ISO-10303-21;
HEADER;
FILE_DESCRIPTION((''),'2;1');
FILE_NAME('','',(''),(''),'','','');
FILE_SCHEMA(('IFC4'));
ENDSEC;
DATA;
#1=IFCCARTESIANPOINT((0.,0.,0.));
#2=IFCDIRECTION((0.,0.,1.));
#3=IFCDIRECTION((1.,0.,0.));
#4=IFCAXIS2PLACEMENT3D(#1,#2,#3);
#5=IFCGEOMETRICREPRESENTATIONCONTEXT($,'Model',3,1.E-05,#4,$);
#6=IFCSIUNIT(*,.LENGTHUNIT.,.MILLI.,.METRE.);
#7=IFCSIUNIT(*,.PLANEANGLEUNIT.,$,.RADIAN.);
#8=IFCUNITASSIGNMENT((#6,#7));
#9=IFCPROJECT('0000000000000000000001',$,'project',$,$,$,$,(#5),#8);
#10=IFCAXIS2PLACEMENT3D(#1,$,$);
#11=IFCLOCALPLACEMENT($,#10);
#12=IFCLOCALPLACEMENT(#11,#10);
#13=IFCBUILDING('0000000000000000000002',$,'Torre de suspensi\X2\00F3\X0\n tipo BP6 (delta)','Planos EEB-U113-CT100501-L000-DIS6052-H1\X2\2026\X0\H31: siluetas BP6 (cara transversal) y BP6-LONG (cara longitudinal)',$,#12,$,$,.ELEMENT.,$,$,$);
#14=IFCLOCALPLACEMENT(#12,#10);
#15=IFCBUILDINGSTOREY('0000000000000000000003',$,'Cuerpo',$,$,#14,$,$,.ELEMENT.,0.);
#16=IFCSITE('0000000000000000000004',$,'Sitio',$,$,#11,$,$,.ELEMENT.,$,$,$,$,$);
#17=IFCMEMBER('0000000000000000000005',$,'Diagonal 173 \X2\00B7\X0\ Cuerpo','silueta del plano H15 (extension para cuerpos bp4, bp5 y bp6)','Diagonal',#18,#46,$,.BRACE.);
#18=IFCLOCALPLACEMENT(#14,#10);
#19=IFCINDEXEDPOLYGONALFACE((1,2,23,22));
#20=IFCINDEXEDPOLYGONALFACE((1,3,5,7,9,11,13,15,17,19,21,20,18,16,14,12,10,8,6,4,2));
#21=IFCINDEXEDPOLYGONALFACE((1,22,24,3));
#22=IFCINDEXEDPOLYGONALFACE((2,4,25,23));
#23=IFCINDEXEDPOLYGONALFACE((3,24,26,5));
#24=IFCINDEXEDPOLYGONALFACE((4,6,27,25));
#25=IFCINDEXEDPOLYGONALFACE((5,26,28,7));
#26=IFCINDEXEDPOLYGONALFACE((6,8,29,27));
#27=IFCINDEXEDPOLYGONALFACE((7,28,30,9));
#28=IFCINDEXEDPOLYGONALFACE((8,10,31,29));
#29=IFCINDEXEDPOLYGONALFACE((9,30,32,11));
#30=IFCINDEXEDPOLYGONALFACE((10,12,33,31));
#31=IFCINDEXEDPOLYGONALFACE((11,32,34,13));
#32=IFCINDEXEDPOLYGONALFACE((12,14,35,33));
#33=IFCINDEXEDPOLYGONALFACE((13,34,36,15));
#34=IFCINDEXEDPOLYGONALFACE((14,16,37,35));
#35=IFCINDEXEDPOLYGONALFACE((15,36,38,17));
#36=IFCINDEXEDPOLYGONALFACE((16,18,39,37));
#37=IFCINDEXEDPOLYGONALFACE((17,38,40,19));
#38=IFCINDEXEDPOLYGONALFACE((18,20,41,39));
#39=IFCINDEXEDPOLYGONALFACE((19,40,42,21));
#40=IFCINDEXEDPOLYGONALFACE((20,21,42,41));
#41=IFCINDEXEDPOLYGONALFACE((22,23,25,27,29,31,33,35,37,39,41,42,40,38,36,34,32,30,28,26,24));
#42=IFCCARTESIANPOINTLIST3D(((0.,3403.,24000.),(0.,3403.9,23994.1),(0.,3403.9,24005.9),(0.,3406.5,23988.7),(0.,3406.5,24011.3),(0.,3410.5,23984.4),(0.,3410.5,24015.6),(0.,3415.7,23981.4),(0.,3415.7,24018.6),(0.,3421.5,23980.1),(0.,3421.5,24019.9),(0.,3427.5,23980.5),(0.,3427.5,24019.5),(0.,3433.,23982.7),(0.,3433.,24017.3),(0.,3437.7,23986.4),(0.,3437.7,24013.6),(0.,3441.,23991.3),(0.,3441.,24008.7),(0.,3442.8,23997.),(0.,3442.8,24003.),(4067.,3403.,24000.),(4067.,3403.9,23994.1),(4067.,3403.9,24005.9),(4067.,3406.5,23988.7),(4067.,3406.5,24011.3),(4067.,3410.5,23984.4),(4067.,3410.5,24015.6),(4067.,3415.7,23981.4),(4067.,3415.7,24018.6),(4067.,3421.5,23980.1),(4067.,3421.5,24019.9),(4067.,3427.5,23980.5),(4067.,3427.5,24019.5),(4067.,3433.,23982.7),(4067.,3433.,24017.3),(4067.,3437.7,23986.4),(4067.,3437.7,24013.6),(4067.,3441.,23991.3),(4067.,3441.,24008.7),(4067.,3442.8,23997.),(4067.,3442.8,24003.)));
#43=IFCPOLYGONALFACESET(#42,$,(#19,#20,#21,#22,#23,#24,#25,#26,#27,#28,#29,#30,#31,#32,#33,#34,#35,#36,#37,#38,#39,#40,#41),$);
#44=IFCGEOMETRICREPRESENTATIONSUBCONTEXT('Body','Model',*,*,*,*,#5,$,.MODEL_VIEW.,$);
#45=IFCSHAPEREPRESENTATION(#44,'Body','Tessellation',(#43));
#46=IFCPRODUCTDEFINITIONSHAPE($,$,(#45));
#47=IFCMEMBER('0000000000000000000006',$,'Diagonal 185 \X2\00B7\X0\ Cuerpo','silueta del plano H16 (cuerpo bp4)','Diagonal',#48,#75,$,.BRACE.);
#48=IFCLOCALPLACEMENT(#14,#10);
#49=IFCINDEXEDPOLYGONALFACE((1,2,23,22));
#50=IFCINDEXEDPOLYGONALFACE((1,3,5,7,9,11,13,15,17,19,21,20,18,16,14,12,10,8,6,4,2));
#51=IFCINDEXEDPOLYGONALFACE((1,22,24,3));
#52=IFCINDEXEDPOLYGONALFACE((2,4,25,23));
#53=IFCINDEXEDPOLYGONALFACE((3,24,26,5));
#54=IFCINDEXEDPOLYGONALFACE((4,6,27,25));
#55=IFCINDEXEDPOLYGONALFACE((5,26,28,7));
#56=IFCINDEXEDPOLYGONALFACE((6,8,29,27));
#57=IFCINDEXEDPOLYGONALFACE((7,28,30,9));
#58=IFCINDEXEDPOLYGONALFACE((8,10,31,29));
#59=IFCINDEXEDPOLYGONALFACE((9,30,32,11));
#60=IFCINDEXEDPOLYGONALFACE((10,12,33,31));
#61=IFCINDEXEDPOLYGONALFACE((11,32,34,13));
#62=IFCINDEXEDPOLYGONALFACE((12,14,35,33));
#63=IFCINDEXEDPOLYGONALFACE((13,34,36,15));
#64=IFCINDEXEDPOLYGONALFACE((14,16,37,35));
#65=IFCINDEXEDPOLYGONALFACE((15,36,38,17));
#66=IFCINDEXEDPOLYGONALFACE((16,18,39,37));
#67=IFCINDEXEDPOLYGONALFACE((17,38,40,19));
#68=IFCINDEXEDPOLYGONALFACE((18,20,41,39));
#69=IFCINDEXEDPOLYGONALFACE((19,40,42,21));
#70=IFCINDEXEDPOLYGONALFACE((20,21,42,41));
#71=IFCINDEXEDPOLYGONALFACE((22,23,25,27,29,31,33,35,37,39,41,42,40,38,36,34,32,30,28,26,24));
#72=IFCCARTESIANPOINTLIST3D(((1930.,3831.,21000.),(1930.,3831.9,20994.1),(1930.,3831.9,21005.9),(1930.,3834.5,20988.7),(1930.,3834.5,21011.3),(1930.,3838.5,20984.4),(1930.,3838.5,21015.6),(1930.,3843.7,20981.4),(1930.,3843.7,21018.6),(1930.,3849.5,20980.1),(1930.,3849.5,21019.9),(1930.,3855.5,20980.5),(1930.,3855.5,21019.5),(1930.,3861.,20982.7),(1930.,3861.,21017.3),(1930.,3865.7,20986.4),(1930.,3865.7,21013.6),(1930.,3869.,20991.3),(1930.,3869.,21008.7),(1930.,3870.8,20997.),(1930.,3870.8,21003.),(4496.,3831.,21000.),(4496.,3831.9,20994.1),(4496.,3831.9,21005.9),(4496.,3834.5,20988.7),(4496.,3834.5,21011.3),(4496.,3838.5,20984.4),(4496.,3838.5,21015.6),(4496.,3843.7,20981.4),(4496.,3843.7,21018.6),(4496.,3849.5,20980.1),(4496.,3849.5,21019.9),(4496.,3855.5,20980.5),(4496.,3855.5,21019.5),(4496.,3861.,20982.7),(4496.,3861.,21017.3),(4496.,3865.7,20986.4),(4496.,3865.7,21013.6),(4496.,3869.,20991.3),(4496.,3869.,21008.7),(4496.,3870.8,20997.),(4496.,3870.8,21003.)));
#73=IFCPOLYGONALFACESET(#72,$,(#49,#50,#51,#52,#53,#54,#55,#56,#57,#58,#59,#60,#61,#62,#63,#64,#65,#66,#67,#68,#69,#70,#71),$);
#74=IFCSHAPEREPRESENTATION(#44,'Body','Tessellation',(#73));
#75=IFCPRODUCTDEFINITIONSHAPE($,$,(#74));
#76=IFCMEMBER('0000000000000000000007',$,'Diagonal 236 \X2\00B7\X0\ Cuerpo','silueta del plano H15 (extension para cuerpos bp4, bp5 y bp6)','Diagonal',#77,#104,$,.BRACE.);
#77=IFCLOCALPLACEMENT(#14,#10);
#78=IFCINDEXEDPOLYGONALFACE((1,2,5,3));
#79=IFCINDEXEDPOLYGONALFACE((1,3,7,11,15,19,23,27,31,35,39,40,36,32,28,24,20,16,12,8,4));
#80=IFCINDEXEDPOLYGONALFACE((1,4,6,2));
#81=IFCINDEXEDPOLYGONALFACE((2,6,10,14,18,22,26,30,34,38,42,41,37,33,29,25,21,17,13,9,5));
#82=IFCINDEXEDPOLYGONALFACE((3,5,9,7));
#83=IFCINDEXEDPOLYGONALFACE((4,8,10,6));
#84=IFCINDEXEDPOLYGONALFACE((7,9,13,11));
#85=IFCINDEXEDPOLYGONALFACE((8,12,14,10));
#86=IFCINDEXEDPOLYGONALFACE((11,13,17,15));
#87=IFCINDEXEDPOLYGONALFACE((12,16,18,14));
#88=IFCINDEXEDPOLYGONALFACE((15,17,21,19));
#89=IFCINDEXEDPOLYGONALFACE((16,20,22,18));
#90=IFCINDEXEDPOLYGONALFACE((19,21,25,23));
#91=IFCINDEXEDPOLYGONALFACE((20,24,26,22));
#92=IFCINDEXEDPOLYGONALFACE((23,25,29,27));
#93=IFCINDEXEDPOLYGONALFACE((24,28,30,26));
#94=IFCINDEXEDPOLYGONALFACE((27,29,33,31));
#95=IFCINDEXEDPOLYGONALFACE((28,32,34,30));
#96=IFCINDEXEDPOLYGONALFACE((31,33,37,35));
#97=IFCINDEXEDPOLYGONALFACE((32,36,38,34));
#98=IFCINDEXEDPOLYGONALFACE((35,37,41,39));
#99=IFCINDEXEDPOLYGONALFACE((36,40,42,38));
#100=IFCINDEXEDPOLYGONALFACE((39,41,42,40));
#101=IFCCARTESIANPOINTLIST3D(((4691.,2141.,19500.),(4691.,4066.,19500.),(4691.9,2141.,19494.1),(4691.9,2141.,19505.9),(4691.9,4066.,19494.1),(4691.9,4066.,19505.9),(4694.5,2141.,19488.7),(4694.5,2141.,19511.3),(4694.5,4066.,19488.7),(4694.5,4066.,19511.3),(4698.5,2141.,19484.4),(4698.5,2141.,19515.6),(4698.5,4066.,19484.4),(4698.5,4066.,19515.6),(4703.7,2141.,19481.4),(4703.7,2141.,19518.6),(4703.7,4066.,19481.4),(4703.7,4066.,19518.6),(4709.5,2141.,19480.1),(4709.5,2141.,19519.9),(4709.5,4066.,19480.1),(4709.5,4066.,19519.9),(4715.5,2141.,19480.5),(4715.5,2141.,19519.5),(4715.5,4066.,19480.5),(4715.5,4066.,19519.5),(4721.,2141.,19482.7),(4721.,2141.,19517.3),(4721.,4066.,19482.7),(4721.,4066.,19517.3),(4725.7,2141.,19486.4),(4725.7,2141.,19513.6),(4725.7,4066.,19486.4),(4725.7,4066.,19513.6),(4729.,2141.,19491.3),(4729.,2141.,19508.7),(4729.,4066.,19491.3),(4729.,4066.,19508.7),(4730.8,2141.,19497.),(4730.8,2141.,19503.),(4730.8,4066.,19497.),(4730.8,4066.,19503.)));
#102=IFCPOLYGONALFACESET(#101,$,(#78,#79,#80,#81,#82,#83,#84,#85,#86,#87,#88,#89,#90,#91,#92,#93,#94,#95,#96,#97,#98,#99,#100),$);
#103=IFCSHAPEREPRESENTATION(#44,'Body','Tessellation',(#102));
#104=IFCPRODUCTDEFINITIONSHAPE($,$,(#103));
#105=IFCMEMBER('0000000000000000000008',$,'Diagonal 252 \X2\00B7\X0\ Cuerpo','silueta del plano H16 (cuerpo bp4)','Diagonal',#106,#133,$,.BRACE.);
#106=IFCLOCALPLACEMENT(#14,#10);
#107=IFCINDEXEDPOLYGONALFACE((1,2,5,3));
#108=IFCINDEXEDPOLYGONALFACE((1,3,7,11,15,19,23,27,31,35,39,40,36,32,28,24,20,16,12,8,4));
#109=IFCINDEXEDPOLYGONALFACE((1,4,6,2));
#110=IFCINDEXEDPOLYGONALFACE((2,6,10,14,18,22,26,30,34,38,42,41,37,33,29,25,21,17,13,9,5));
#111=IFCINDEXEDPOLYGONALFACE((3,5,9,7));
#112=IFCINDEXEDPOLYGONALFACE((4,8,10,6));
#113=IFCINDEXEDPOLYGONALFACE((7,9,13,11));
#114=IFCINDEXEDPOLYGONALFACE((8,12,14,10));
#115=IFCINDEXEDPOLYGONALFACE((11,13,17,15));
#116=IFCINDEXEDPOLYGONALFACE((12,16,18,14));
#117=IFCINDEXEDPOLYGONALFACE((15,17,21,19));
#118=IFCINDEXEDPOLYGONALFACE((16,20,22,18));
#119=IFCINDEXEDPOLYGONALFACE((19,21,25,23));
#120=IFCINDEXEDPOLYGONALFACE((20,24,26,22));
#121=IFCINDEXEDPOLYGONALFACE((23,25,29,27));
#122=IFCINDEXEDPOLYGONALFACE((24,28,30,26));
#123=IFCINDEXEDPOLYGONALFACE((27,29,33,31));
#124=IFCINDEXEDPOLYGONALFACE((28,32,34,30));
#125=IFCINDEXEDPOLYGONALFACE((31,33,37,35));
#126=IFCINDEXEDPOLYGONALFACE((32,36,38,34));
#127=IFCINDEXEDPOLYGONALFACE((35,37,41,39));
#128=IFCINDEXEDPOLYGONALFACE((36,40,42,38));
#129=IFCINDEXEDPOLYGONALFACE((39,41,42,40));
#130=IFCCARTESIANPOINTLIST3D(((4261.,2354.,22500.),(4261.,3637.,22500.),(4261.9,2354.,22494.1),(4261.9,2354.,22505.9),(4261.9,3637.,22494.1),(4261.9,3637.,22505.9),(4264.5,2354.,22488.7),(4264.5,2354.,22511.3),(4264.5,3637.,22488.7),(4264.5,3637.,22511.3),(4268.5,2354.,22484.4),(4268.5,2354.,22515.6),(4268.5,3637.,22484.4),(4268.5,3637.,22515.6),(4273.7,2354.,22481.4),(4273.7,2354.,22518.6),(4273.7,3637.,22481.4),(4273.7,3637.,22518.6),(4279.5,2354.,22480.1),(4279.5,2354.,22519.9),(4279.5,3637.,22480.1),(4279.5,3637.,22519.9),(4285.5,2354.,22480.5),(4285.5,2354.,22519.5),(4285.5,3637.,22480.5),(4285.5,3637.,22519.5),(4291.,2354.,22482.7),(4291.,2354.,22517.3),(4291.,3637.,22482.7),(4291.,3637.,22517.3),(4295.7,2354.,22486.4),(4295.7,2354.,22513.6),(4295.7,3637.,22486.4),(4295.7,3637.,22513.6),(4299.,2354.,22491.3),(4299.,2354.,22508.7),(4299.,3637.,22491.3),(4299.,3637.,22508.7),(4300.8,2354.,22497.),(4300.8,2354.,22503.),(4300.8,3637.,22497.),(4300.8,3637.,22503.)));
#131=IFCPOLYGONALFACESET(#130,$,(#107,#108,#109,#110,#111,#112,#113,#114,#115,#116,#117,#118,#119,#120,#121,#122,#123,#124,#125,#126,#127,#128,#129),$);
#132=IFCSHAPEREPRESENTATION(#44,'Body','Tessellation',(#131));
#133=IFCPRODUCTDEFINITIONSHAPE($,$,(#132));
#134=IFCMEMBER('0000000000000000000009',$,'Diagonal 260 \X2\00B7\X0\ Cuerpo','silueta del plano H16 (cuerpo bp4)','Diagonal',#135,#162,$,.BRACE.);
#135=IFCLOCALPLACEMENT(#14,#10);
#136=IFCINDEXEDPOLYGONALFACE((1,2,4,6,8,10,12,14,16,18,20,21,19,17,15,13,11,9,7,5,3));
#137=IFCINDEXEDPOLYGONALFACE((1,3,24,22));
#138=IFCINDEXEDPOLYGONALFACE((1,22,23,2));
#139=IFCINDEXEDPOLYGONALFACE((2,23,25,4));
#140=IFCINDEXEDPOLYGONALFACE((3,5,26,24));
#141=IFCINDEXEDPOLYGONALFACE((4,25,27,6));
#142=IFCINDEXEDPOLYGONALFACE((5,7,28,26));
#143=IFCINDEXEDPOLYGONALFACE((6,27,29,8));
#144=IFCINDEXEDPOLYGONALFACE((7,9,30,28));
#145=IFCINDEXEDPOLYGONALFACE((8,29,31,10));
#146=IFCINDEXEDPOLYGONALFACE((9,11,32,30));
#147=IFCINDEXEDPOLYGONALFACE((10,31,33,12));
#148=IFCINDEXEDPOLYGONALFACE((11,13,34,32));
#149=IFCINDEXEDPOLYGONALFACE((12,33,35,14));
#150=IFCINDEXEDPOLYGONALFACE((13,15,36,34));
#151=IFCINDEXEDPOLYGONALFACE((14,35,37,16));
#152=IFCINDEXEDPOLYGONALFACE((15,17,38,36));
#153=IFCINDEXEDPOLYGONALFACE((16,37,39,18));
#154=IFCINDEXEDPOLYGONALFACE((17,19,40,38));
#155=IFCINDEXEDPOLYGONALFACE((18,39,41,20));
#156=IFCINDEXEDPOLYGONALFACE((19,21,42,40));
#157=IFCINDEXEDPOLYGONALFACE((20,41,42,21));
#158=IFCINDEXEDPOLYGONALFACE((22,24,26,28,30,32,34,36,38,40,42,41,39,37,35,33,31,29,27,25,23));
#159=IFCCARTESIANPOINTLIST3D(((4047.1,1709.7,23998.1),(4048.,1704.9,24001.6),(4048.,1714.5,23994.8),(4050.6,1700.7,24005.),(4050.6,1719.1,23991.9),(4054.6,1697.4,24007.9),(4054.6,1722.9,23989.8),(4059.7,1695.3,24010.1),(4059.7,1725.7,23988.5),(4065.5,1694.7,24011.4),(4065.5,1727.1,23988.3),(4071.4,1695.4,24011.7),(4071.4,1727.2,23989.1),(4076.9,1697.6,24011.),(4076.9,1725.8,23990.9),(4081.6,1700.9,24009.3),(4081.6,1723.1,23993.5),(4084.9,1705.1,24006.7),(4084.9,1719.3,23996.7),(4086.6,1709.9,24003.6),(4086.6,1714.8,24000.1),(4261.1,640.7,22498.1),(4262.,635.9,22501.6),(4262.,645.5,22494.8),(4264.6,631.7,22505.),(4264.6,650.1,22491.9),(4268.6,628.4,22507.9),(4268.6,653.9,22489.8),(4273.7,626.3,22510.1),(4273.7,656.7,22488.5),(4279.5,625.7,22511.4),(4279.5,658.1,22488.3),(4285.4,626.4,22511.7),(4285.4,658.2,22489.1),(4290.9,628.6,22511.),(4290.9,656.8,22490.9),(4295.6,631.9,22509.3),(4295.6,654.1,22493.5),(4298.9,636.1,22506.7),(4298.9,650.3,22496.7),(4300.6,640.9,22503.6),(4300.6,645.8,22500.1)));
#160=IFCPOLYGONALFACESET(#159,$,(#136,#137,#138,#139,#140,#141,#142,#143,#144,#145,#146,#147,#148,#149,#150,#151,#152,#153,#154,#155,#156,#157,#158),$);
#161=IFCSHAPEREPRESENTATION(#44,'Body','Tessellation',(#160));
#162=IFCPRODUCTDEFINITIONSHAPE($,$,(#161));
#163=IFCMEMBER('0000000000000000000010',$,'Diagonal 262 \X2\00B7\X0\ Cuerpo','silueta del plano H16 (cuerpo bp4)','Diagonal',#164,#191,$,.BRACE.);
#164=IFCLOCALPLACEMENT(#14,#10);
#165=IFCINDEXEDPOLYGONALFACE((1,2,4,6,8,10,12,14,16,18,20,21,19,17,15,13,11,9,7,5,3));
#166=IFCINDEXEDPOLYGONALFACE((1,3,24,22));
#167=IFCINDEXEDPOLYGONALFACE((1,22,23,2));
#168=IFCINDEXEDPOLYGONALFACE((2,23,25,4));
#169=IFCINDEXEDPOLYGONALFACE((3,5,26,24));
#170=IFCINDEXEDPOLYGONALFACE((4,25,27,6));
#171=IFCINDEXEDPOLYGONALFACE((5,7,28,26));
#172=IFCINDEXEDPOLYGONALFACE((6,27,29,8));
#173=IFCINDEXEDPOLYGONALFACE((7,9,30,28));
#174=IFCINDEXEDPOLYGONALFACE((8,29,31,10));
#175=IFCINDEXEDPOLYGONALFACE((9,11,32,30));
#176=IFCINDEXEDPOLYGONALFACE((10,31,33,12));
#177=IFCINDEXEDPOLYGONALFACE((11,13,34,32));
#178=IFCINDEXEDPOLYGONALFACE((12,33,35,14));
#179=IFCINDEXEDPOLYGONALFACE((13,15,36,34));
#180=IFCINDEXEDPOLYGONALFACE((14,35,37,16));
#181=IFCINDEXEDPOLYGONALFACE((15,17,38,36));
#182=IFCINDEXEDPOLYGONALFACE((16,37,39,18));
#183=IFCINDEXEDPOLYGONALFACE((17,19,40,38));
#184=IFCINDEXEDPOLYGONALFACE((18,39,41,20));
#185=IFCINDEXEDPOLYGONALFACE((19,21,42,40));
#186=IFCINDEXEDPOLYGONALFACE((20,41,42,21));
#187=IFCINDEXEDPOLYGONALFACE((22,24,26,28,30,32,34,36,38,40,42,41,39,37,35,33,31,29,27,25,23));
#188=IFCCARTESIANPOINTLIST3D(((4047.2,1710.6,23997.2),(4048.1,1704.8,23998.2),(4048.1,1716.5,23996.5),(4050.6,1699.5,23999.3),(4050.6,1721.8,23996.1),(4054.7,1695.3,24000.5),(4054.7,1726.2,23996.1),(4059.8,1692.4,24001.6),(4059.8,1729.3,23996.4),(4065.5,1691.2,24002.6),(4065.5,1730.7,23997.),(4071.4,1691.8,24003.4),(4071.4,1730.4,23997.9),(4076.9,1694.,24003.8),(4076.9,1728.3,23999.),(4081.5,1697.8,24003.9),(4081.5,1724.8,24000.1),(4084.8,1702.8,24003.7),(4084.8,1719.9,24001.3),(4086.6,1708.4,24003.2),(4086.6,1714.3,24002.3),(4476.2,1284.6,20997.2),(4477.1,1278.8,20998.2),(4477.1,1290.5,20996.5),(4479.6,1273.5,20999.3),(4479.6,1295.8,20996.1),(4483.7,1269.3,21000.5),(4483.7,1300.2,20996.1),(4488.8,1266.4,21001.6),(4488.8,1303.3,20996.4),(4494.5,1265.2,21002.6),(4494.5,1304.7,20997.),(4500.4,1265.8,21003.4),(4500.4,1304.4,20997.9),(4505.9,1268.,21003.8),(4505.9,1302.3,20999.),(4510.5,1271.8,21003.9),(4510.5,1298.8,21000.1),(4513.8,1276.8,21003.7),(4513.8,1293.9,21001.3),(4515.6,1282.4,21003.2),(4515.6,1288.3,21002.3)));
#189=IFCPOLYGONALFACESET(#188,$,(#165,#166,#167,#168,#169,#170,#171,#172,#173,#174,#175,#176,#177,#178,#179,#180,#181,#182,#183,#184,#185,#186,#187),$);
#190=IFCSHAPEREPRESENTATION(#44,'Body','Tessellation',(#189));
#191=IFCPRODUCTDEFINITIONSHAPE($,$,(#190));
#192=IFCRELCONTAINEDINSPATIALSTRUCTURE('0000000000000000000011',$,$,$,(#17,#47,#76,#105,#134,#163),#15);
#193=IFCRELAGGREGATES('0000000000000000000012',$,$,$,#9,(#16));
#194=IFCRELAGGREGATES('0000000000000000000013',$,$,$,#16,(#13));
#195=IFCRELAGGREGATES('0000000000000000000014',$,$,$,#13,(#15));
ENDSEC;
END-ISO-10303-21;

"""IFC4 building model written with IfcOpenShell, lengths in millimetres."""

from ifc_helpers import new_model, si_unit, frame, origin, origin_with_axes, place, context, subcontext, project, spatial, circle, extrude, element, save


model = new_model("IFC4")

# Units and contexts
model_context = context("Model", 3, precision=1e-05, world=origin_with_axes())
body_context = subcontext(model_context, "Body", "Model", "MODEL_VIEW")
ifc_project = project(units=[si_unit("LENGTHUNIT", "METRE", prefix="MILLI"), si_unit("PLANEANGLEUNIT", "RADIAN")], contexts=[model_context])

# Site, building, storey
site_placement = place(None, origin())
site = spatial("IfcSite", under=ifc_project, at=site_placement, Name="Sitio", CompositionType="ELEMENT")
building_placement = place(site_placement, origin())
building = spatial("IfcBuilding", under=site, at=building_placement, Name="Torre de suspensión tipo BP6 (delta)", Description="Planos EEB-U113-CT100501-L000-DIS6052-H1…H31: siluetas BP6 (cara transversal) y BP6-LONG (cara longitudinal)", CompositionType="ELEMENT")
storey_placement = place(building_placement, origin())
storey = spatial("IfcBuildingStorey", under=building, at=storey_placement, Name="Cuerpo", CompositionType="ELEMENT", Elevation=0.0)

# Members
member_1_placement = place(storey_placement, frame((4067.0, 3423.0, 24000.0), z_axis=(-1.0, 0.0, 0.0), x_axis=(0.0, -1.0, 0.0)))
element("IfcMember", 1, at=member_1_placement, inside=storey, Name="Diagonal 173 · Cuerpo", Description="silueta del plano H15 (extension para cuerpos bp4, bp5 y bp6)", ObjectType="Diagonal", PredefinedType="BRACE", context=body_context, shape_type="SweptSolid", body=[
    extrude(circle(Radius=20.0), None, (0.0, 0.0, 1.0), 4067.0),
])
member_2_placement = place(storey_placement, frame((4496.0, 3851.0, 21000.0), z_axis=(-1.0, 0.0, 0.0), x_axis=(0.0, -1.0, 0.0)))
element("IfcMember", 2, at=member_2_placement, inside=storey, Name="Diagonal 185 · Cuerpo", Description="silueta del plano H16 (cuerpo bp4)", ObjectType="Diagonal", PredefinedType="BRACE", context=body_context, shape_type="SweptSolid", body=[
    extrude(circle(Radius=20.0), None, (0.0, 0.0, 1.0), 2566.0),
])
member_3_placement = place(storey_placement, frame((4711.0, 2141.0, 19500.0), z_axis=(0.0, 1.0, 0.0), x_axis=(-1.0, 0.0, 0.0)))
element("IfcMember", 3, at=member_3_placement, inside=storey, Name="Diagonal 236 · Cuerpo", Description="silueta del plano H15 (extension para cuerpos bp4, bp5 y bp6)", ObjectType="Diagonal", PredefinedType="BRACE", context=body_context, shape_type="SweptSolid", body=[
    extrude(circle(Radius=20.0), None, (0.0, 0.0, 1.0), 1925.0),
])
member_4_placement = place(storey_placement, frame((4281.0, 2354.0, 22500.0), z_axis=(0.0, 1.0, 0.0), x_axis=(-1.0, 0.0, 0.0)))
element("IfcMember", 4, at=member_4_placement, inside=storey, Name="Diagonal 252 · Cuerpo", Description="silueta del plano H16 (cuerpo bp4)", ObjectType="Diagonal", PredefinedType="BRACE", context=body_context, shape_type="SweptSolid", body=[
    extrude(circle(Radius=20.0), None, (0.0, 0.0, 1.0), 1283.0),
])
member_5_placement = place(storey_placement, frame((4281.0, 642.0, 22500.0), z_axis=(-0.115405, 0.576487, 0.808915), x_axis=(-0.993318, -0.066977, -0.093981)))
element("IfcMember", 5, at=member_5_placement, inside=storey, Name="Diagonal 260 · Cuerpo", Description="silueta del plano H16 (cuerpo bp4)", ObjectType="Diagonal", PredefinedType="BRACE", context=body_context, shape_type="SweptSolid", body=[
    extrude(circle(Radius=20.0), None, (0.0, 0.0, 1.0), 1854.3),
])
member_6_placement = place(storey_placement, frame((4067.0, 1711.0, 24000.0), z_axis=(0.140182, -0.139201, -0.980292), x_axis=(-0.990126, -0.019708, -0.138789)))
element("IfcMember", 6, at=member_6_placement, inside=storey, Name="Diagonal 262 · Cuerpo", Description="silueta del plano H16 (cuerpo bp4)", ObjectType="Diagonal", PredefinedType="BRACE", context=body_context, shape_type="SweptSolid", body=[
    extrude(circle(Radius=20.0), None, (0.0, 0.0, 1.0), 3060.3),
])

save(model, "model.ifc")
